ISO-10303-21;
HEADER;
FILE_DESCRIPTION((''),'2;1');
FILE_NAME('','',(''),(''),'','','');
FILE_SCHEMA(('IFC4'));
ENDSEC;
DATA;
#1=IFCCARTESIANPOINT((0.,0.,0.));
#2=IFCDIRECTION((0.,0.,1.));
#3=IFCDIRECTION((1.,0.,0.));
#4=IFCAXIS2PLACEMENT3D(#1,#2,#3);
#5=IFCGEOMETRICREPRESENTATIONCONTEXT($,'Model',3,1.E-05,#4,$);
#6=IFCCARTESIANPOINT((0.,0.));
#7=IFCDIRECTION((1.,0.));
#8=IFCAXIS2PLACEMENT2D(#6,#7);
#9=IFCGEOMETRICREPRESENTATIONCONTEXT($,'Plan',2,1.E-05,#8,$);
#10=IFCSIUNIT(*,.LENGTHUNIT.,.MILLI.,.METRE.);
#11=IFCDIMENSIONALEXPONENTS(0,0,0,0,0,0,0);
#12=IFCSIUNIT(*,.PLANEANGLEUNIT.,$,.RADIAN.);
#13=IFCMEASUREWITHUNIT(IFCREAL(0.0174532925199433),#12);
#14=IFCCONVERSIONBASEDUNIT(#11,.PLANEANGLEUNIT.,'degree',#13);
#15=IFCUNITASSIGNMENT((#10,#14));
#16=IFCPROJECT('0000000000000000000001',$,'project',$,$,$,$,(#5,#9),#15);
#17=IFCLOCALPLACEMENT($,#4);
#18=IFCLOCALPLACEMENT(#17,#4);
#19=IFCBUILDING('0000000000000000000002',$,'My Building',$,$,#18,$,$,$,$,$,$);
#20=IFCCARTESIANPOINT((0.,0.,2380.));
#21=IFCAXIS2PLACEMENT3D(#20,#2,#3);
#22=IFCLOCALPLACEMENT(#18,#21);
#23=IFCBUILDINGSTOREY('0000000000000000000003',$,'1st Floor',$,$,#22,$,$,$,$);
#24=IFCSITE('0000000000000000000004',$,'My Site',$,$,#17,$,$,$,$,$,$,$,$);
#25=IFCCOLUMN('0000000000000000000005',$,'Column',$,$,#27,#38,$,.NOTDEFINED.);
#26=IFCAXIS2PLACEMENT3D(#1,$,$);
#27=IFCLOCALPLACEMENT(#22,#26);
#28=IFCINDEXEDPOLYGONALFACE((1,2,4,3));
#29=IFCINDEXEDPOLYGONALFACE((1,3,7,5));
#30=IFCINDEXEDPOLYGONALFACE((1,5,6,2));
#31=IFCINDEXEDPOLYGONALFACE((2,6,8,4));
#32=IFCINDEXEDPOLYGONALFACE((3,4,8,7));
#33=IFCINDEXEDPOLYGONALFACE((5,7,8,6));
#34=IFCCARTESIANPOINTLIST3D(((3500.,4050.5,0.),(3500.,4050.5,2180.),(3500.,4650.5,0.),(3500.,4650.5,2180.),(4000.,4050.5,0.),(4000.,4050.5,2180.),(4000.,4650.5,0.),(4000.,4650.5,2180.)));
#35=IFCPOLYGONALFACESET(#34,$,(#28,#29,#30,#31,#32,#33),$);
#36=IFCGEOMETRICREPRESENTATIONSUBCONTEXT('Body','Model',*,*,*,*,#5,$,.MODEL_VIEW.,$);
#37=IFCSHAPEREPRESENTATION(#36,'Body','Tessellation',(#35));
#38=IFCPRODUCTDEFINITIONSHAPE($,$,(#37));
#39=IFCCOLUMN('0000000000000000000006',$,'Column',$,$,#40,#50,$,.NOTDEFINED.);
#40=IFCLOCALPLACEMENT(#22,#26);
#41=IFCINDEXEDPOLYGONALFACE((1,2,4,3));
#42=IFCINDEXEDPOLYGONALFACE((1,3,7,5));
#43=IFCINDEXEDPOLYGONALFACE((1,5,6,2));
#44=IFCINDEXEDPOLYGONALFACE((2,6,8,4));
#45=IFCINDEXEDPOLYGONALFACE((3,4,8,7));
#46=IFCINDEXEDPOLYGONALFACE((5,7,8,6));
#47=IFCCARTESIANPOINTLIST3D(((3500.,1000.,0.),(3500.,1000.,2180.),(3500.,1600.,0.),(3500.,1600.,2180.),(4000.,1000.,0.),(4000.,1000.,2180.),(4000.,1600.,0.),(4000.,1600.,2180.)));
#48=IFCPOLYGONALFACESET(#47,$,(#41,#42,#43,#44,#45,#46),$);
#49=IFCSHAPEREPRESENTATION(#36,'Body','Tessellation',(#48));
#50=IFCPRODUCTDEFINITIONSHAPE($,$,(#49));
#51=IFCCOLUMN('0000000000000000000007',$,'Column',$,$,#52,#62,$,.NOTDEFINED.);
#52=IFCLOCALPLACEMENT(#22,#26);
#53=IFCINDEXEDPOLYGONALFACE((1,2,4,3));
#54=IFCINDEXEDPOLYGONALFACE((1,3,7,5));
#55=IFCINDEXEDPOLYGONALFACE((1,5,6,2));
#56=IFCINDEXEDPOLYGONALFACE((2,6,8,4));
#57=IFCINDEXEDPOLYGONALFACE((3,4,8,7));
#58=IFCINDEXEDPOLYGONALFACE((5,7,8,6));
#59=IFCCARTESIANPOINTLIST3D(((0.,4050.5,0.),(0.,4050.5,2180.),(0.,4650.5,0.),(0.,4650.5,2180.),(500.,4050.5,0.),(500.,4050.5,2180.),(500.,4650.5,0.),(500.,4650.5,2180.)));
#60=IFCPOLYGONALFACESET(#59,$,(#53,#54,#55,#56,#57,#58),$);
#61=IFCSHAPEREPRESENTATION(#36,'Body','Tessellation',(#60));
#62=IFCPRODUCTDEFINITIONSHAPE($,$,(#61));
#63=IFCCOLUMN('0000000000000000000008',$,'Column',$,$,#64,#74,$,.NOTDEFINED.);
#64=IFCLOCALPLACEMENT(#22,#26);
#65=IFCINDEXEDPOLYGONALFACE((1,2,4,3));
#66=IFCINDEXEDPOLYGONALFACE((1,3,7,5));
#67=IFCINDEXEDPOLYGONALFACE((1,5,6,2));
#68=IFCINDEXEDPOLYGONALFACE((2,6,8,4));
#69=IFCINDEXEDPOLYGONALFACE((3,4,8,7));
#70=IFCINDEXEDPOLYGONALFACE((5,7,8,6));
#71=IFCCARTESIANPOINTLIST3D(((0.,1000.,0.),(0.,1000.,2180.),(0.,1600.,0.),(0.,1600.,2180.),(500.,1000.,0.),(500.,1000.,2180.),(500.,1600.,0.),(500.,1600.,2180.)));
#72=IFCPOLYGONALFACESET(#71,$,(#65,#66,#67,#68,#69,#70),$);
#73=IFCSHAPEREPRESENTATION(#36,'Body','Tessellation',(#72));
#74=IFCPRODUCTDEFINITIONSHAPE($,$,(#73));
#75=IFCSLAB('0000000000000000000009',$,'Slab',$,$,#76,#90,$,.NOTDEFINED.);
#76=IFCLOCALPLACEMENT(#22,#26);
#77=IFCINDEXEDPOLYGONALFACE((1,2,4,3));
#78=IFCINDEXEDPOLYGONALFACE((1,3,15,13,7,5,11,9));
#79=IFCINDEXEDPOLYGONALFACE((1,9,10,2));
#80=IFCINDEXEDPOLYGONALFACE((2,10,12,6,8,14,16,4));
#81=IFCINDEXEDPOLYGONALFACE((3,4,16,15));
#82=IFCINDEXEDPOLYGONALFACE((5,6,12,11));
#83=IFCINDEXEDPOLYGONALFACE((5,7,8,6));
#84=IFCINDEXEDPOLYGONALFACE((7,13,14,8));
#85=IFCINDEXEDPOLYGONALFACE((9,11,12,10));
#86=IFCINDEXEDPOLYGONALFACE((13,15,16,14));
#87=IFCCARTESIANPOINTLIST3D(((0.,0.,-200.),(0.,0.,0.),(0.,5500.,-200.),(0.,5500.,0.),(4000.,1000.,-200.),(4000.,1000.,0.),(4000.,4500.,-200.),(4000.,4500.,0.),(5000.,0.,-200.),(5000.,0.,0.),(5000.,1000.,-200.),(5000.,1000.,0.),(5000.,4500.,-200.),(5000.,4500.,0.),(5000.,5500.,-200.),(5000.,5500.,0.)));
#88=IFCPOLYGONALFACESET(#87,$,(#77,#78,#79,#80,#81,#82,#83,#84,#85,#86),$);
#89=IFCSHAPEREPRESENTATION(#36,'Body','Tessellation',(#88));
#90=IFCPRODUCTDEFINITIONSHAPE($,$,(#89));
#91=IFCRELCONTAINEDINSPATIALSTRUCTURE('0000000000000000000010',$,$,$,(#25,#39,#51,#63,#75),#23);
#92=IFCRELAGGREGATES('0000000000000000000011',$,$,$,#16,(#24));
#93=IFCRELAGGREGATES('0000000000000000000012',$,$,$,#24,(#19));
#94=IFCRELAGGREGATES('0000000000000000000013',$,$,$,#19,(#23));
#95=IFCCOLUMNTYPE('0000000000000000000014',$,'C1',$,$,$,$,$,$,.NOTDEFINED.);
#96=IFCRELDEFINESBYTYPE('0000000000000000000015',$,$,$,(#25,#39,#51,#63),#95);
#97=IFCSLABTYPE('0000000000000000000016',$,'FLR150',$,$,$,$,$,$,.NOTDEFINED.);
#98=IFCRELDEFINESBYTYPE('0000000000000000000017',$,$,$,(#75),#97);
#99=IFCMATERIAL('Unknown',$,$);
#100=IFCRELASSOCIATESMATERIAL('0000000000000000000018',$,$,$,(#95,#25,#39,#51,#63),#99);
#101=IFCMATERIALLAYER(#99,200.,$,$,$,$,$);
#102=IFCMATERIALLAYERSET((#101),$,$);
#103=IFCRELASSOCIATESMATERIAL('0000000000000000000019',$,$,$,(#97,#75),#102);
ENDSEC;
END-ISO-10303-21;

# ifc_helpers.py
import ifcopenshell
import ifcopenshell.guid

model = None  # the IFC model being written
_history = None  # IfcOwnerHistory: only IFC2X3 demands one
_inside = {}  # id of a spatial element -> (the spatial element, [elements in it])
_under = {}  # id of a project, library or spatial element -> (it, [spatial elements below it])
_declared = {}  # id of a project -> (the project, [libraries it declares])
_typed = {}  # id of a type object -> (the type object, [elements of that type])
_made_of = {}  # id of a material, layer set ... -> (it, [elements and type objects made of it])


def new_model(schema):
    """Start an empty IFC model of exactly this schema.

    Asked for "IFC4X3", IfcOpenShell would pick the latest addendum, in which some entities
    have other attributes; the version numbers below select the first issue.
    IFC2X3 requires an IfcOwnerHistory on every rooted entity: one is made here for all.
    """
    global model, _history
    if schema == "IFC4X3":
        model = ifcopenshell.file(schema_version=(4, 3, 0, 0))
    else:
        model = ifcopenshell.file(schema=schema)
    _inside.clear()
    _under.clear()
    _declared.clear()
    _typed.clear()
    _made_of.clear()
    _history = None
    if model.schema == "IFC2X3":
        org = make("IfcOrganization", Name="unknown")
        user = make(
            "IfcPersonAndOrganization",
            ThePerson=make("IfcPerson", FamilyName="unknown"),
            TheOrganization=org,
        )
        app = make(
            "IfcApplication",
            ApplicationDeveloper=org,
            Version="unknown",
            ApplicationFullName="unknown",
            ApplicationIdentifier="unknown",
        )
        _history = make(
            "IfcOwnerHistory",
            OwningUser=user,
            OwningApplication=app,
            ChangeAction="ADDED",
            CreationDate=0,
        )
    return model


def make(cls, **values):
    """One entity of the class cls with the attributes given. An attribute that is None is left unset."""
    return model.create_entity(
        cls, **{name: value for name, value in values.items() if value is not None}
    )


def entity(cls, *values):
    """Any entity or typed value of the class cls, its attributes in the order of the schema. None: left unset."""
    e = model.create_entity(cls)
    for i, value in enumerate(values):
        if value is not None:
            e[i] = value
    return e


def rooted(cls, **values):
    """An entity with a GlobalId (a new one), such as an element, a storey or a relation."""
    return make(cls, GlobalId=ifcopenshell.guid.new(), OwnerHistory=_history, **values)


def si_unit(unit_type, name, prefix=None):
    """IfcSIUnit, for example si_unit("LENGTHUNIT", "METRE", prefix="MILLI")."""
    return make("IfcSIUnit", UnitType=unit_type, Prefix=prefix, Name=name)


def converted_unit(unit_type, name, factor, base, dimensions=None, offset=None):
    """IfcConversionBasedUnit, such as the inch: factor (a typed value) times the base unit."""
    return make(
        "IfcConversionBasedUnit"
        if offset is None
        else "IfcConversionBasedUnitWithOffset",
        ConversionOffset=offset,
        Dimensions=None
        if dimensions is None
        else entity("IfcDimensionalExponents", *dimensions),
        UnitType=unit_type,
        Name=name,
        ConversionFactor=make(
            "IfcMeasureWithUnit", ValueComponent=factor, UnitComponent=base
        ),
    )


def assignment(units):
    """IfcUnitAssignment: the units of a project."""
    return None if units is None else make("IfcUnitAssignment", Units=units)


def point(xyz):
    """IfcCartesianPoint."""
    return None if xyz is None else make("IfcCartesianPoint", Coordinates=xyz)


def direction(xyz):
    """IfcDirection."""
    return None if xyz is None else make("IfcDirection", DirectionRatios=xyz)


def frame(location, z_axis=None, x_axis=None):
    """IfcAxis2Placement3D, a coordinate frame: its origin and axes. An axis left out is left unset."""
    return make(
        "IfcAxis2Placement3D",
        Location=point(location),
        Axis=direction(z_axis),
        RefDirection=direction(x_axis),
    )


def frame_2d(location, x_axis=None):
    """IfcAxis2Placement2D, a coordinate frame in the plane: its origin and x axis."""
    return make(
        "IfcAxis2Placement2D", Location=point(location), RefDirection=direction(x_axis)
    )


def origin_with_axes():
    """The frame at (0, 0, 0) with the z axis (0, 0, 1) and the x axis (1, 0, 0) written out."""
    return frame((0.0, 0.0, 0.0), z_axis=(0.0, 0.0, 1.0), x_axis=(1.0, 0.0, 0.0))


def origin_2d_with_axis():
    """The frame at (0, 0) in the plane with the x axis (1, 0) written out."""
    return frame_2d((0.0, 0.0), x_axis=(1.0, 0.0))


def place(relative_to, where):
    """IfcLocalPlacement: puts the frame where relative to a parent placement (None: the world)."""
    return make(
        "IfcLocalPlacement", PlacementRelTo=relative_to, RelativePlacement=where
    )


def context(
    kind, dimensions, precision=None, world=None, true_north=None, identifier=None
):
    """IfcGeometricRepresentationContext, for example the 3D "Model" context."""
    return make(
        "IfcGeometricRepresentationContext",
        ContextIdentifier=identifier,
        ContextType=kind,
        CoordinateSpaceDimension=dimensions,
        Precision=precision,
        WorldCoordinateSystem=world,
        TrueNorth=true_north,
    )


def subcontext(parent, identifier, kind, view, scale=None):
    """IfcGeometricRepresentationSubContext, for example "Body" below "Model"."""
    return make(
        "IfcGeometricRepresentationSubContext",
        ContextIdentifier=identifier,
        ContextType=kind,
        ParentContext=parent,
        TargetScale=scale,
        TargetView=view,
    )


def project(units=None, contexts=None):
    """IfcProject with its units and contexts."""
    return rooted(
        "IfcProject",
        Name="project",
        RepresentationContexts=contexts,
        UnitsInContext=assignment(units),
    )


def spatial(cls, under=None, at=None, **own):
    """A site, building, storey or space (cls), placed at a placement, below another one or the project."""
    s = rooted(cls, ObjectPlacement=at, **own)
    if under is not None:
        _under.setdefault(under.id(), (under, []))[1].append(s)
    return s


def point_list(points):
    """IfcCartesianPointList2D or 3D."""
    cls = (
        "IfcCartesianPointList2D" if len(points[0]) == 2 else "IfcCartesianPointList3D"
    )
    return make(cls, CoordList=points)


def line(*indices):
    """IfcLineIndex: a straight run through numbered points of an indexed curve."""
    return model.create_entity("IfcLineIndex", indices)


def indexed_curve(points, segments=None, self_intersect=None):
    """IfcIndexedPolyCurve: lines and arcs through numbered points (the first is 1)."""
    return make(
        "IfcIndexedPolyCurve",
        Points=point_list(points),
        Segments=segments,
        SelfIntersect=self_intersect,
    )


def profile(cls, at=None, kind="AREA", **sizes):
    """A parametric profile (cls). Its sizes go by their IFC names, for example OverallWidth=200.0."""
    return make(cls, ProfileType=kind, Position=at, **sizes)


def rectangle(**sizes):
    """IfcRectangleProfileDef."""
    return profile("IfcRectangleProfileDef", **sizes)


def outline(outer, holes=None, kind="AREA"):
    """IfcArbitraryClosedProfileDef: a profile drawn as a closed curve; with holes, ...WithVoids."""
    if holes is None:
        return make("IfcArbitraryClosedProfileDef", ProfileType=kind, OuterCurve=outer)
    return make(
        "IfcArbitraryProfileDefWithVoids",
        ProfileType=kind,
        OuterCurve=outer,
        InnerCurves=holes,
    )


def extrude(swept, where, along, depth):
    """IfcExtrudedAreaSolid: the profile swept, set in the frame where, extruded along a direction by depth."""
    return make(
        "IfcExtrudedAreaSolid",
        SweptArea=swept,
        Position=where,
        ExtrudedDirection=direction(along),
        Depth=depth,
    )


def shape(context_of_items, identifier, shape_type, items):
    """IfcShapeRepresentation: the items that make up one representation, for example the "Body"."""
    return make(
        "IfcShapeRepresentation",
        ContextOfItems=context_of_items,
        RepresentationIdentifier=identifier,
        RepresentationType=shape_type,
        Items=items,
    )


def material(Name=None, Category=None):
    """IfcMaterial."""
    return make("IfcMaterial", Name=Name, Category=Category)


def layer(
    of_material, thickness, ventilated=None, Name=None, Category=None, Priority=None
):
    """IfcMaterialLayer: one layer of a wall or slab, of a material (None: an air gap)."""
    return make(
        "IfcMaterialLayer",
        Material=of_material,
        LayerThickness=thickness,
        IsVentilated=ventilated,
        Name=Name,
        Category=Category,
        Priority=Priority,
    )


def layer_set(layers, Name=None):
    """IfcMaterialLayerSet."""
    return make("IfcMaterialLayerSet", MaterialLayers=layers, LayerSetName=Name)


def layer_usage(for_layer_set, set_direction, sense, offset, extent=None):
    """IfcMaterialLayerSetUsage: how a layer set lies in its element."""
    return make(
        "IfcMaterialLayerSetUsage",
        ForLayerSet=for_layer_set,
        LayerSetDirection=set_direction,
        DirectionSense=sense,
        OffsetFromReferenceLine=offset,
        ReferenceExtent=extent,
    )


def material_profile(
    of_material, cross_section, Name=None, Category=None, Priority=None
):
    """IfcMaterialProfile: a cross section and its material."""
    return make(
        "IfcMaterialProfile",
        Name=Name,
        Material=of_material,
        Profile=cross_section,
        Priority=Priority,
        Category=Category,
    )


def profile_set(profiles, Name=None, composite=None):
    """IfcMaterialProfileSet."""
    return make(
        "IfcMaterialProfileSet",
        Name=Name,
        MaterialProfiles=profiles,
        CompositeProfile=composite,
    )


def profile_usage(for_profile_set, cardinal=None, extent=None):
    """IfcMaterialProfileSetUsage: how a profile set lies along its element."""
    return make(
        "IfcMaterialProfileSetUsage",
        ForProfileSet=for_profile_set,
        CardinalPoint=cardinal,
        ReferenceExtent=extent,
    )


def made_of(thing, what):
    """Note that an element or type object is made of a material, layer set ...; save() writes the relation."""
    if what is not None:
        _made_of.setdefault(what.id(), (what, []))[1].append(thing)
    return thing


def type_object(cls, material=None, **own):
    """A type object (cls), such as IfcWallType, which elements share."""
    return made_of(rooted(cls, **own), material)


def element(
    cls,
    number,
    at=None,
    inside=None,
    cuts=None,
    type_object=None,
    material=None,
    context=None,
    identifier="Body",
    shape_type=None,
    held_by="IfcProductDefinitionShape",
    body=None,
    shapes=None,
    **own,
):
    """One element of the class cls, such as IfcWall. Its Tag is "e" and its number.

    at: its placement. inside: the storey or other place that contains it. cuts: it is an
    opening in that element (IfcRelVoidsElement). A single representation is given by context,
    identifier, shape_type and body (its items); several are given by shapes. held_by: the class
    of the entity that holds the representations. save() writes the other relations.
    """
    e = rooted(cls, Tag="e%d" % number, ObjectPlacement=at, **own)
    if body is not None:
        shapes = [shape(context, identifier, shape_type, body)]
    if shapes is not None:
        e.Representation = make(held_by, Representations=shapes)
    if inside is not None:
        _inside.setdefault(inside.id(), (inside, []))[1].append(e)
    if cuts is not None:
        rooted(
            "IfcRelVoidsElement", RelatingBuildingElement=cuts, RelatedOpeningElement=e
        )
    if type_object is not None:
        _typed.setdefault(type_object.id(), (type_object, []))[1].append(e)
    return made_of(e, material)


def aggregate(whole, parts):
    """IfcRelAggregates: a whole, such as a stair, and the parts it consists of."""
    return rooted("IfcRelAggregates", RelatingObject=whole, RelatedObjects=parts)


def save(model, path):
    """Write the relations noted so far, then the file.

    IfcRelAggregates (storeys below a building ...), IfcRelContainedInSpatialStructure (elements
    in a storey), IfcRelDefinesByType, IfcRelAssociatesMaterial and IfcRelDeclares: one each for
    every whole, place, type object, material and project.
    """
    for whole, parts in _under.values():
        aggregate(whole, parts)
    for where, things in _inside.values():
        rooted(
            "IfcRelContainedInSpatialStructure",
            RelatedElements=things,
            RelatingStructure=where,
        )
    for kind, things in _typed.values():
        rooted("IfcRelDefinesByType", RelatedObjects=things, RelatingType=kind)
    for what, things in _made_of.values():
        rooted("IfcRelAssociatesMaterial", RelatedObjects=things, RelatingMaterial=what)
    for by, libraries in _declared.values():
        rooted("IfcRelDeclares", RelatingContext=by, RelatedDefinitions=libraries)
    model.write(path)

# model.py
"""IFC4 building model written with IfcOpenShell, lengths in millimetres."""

from ifc_helpers import new_model, entity, si_unit, converted_unit, frame, origin_with_axes, origin_2d_with_axis, place, context, subcontext, project, spatial, line, indexed_curve, rectangle, outline, extrude, material, layer, layer_set, layer_usage, material_profile, profile_set, profile_usage, type_object, element, save


model = new_model("IFC4")

# Units and contexts
model_context = context("Model", 3, precision=1e-05, world=origin_with_axes())
plan_context = context("Plan", 2, precision=1e-05, world=origin_2d_with_axis())
body_context = subcontext(model_context, "Body", "Model", "MODEL_VIEW")
ifc_project = project(units=[si_unit("LENGTHUNIT", "METRE", prefix="MILLI"), converted_unit("PLANEANGLEUNIT", "degree", entity("IfcReal", 0.0174532925199433), si_unit("PLANEANGLEUNIT", "RADIAN"), dimensions=[0, 0, 0, 0, 0, 0, 0])], contexts=[model_context, plan_context])

# Site, building, storey
site_placement = place(None, origin_with_axes())
site = spatial("IfcSite", under=ifc_project, at=site_placement, Name="My Site")
building_placement = place(site_placement, origin_with_axes())
building = spatial("IfcBuilding", under=site, at=building_placement, Name="My Building")
storey_placement = place(building_placement, frame((0.0, 0.0, 2380.0), z_axis=(0.0, 0.0, 1.0), x_axis=(1.0, 0.0, 0.0)))
storey = spatial("IfcBuildingStorey", under=building, at=storey_placement, Name="1st Floor")

# Columns
ifc_material = material(Name="Unknown")
ifc_material_profile = material_profile(ifc_material, rectangle(XDim=500.0, YDim=600.0))
ifc_profile_set = profile_set([ifc_material_profile])
ifc_profile_usage_1 = profile_usage(ifc_profile_set, cardinal=5)
column_type = type_object("IfcColumnType", Name="C1", PredefinedType="NOTDEFINED", material=ifc_profile_set)
column_1_placement = place(storey_placement, frame((3750.0, 4350.5, 0.0), z_axis=(0.0, 0.0, 1.0), x_axis=(1.0, 0.0, 0.0)))
element("IfcColumn", 1, at=column_1_placement, inside=storey, type_object=column_type, material=ifc_profile_usage_1, Name="Column", PredefinedType="NOTDEFINED", context=body_context, shape_type="SweptSolid", body=[
    extrude(rectangle(XDim=500.0, YDim=600.0), origin_with_axes(), (0.0, 0.0, 1.0), 2180.0),
])
ifc_profile_usage_2 = profile_usage(ifc_profile_set, cardinal=5)
column_2_placement = place(storey_placement, frame((3750.0, 1300.0, 0.0), z_axis=(0.0, 0.0, 1.0), x_axis=(1.0, 0.0, 0.0)))
element("IfcColumn", 2, at=column_2_placement, inside=storey, type_object=column_type, material=ifc_profile_usage_2, Name="Column", PredefinedType="NOTDEFINED", context=body_context, shape_type="SweptSolid", body=[
    extrude(rectangle(XDim=500.0, YDim=600.0), origin_with_axes(), (0.0, 0.0, 1.0), 2180.0),
])
ifc_profile_usage_3 = profile_usage(ifc_profile_set, cardinal=5)
column_3_placement = place(storey_placement, frame((250.0, 4350.5, 0.0), z_axis=(0.0, 0.0, 1.0), x_axis=(1.0, 0.0, 0.0)))
element("IfcColumn", 3, at=column_3_placement, inside=storey, type_object=column_type, material=ifc_profile_usage_3, Name="Column", PredefinedType="NOTDEFINED", context=body_context, shape_type="SweptSolid", body=[
    extrude(rectangle(XDim=500.0, YDim=600.0), origin_with_axes(), (0.0, 0.0, 1.0), 2180.0),
])
ifc_profile_usage_4 = profile_usage(ifc_profile_set, cardinal=5)
column_4_placement = place(storey_placement, frame((250.0, 1300.0, 0.0), z_axis=(0.0, 0.0, 1.0), x_axis=(1.0, 0.0, 0.0)))
element("IfcColumn", 4, at=column_4_placement, inside=storey, type_object=column_type, material=ifc_profile_usage_4, Name="Column", PredefinedType="NOTDEFINED", context=body_context, shape_type="SweptSolid", body=[
    extrude(rectangle(XDim=500.0, YDim=600.0), origin_with_axes(), (0.0, 0.0, 1.0), 2180.0),
])

# Slab
ifc_layer = layer(ifc_material, 200.0)
ifc_layer_set = layer_set([ifc_layer])
ifc_layer_usage = layer_usage(ifc_layer_set, "AXIS3", "POSITIVE", 0.0)
slab_type = type_object("IfcSlabType", Name="FLR150", PredefinedType="NOTDEFINED", material=ifc_layer_set)
slab_placement = place(storey_placement, frame((0.0, 0.0, -200.0), z_axis=(0.0, 0.0, 1.0), x_axis=(1.0, 0.0, 0.0)))
element("IfcSlab", 5, at=slab_placement, inside=storey, type_object=slab_type, material=ifc_layer_usage, Name="Slab", PredefinedType="NOTDEFINED", context=body_context, shape_type="SweptSolid", body=[
    extrude(outline(indexed_curve([(0.0, 0.0), (5000.0, 0.0), (5000.0, 5500.0), (0.0, 5500.0), (5000.0, 4500.0), (5000.0, 1000.0), (4000.0, 4500.0), (4000.0, 1000.0)], segments=[line(6, 2), line(2, 1), line(1, 4), line(4, 3), line(3, 5), line(5, 7), line(7, 8), line(8, 6)], self_intersect=False)), None, (0.0, 0.0, 1.0), 200.0),
])

save(model, "model.ifc")
